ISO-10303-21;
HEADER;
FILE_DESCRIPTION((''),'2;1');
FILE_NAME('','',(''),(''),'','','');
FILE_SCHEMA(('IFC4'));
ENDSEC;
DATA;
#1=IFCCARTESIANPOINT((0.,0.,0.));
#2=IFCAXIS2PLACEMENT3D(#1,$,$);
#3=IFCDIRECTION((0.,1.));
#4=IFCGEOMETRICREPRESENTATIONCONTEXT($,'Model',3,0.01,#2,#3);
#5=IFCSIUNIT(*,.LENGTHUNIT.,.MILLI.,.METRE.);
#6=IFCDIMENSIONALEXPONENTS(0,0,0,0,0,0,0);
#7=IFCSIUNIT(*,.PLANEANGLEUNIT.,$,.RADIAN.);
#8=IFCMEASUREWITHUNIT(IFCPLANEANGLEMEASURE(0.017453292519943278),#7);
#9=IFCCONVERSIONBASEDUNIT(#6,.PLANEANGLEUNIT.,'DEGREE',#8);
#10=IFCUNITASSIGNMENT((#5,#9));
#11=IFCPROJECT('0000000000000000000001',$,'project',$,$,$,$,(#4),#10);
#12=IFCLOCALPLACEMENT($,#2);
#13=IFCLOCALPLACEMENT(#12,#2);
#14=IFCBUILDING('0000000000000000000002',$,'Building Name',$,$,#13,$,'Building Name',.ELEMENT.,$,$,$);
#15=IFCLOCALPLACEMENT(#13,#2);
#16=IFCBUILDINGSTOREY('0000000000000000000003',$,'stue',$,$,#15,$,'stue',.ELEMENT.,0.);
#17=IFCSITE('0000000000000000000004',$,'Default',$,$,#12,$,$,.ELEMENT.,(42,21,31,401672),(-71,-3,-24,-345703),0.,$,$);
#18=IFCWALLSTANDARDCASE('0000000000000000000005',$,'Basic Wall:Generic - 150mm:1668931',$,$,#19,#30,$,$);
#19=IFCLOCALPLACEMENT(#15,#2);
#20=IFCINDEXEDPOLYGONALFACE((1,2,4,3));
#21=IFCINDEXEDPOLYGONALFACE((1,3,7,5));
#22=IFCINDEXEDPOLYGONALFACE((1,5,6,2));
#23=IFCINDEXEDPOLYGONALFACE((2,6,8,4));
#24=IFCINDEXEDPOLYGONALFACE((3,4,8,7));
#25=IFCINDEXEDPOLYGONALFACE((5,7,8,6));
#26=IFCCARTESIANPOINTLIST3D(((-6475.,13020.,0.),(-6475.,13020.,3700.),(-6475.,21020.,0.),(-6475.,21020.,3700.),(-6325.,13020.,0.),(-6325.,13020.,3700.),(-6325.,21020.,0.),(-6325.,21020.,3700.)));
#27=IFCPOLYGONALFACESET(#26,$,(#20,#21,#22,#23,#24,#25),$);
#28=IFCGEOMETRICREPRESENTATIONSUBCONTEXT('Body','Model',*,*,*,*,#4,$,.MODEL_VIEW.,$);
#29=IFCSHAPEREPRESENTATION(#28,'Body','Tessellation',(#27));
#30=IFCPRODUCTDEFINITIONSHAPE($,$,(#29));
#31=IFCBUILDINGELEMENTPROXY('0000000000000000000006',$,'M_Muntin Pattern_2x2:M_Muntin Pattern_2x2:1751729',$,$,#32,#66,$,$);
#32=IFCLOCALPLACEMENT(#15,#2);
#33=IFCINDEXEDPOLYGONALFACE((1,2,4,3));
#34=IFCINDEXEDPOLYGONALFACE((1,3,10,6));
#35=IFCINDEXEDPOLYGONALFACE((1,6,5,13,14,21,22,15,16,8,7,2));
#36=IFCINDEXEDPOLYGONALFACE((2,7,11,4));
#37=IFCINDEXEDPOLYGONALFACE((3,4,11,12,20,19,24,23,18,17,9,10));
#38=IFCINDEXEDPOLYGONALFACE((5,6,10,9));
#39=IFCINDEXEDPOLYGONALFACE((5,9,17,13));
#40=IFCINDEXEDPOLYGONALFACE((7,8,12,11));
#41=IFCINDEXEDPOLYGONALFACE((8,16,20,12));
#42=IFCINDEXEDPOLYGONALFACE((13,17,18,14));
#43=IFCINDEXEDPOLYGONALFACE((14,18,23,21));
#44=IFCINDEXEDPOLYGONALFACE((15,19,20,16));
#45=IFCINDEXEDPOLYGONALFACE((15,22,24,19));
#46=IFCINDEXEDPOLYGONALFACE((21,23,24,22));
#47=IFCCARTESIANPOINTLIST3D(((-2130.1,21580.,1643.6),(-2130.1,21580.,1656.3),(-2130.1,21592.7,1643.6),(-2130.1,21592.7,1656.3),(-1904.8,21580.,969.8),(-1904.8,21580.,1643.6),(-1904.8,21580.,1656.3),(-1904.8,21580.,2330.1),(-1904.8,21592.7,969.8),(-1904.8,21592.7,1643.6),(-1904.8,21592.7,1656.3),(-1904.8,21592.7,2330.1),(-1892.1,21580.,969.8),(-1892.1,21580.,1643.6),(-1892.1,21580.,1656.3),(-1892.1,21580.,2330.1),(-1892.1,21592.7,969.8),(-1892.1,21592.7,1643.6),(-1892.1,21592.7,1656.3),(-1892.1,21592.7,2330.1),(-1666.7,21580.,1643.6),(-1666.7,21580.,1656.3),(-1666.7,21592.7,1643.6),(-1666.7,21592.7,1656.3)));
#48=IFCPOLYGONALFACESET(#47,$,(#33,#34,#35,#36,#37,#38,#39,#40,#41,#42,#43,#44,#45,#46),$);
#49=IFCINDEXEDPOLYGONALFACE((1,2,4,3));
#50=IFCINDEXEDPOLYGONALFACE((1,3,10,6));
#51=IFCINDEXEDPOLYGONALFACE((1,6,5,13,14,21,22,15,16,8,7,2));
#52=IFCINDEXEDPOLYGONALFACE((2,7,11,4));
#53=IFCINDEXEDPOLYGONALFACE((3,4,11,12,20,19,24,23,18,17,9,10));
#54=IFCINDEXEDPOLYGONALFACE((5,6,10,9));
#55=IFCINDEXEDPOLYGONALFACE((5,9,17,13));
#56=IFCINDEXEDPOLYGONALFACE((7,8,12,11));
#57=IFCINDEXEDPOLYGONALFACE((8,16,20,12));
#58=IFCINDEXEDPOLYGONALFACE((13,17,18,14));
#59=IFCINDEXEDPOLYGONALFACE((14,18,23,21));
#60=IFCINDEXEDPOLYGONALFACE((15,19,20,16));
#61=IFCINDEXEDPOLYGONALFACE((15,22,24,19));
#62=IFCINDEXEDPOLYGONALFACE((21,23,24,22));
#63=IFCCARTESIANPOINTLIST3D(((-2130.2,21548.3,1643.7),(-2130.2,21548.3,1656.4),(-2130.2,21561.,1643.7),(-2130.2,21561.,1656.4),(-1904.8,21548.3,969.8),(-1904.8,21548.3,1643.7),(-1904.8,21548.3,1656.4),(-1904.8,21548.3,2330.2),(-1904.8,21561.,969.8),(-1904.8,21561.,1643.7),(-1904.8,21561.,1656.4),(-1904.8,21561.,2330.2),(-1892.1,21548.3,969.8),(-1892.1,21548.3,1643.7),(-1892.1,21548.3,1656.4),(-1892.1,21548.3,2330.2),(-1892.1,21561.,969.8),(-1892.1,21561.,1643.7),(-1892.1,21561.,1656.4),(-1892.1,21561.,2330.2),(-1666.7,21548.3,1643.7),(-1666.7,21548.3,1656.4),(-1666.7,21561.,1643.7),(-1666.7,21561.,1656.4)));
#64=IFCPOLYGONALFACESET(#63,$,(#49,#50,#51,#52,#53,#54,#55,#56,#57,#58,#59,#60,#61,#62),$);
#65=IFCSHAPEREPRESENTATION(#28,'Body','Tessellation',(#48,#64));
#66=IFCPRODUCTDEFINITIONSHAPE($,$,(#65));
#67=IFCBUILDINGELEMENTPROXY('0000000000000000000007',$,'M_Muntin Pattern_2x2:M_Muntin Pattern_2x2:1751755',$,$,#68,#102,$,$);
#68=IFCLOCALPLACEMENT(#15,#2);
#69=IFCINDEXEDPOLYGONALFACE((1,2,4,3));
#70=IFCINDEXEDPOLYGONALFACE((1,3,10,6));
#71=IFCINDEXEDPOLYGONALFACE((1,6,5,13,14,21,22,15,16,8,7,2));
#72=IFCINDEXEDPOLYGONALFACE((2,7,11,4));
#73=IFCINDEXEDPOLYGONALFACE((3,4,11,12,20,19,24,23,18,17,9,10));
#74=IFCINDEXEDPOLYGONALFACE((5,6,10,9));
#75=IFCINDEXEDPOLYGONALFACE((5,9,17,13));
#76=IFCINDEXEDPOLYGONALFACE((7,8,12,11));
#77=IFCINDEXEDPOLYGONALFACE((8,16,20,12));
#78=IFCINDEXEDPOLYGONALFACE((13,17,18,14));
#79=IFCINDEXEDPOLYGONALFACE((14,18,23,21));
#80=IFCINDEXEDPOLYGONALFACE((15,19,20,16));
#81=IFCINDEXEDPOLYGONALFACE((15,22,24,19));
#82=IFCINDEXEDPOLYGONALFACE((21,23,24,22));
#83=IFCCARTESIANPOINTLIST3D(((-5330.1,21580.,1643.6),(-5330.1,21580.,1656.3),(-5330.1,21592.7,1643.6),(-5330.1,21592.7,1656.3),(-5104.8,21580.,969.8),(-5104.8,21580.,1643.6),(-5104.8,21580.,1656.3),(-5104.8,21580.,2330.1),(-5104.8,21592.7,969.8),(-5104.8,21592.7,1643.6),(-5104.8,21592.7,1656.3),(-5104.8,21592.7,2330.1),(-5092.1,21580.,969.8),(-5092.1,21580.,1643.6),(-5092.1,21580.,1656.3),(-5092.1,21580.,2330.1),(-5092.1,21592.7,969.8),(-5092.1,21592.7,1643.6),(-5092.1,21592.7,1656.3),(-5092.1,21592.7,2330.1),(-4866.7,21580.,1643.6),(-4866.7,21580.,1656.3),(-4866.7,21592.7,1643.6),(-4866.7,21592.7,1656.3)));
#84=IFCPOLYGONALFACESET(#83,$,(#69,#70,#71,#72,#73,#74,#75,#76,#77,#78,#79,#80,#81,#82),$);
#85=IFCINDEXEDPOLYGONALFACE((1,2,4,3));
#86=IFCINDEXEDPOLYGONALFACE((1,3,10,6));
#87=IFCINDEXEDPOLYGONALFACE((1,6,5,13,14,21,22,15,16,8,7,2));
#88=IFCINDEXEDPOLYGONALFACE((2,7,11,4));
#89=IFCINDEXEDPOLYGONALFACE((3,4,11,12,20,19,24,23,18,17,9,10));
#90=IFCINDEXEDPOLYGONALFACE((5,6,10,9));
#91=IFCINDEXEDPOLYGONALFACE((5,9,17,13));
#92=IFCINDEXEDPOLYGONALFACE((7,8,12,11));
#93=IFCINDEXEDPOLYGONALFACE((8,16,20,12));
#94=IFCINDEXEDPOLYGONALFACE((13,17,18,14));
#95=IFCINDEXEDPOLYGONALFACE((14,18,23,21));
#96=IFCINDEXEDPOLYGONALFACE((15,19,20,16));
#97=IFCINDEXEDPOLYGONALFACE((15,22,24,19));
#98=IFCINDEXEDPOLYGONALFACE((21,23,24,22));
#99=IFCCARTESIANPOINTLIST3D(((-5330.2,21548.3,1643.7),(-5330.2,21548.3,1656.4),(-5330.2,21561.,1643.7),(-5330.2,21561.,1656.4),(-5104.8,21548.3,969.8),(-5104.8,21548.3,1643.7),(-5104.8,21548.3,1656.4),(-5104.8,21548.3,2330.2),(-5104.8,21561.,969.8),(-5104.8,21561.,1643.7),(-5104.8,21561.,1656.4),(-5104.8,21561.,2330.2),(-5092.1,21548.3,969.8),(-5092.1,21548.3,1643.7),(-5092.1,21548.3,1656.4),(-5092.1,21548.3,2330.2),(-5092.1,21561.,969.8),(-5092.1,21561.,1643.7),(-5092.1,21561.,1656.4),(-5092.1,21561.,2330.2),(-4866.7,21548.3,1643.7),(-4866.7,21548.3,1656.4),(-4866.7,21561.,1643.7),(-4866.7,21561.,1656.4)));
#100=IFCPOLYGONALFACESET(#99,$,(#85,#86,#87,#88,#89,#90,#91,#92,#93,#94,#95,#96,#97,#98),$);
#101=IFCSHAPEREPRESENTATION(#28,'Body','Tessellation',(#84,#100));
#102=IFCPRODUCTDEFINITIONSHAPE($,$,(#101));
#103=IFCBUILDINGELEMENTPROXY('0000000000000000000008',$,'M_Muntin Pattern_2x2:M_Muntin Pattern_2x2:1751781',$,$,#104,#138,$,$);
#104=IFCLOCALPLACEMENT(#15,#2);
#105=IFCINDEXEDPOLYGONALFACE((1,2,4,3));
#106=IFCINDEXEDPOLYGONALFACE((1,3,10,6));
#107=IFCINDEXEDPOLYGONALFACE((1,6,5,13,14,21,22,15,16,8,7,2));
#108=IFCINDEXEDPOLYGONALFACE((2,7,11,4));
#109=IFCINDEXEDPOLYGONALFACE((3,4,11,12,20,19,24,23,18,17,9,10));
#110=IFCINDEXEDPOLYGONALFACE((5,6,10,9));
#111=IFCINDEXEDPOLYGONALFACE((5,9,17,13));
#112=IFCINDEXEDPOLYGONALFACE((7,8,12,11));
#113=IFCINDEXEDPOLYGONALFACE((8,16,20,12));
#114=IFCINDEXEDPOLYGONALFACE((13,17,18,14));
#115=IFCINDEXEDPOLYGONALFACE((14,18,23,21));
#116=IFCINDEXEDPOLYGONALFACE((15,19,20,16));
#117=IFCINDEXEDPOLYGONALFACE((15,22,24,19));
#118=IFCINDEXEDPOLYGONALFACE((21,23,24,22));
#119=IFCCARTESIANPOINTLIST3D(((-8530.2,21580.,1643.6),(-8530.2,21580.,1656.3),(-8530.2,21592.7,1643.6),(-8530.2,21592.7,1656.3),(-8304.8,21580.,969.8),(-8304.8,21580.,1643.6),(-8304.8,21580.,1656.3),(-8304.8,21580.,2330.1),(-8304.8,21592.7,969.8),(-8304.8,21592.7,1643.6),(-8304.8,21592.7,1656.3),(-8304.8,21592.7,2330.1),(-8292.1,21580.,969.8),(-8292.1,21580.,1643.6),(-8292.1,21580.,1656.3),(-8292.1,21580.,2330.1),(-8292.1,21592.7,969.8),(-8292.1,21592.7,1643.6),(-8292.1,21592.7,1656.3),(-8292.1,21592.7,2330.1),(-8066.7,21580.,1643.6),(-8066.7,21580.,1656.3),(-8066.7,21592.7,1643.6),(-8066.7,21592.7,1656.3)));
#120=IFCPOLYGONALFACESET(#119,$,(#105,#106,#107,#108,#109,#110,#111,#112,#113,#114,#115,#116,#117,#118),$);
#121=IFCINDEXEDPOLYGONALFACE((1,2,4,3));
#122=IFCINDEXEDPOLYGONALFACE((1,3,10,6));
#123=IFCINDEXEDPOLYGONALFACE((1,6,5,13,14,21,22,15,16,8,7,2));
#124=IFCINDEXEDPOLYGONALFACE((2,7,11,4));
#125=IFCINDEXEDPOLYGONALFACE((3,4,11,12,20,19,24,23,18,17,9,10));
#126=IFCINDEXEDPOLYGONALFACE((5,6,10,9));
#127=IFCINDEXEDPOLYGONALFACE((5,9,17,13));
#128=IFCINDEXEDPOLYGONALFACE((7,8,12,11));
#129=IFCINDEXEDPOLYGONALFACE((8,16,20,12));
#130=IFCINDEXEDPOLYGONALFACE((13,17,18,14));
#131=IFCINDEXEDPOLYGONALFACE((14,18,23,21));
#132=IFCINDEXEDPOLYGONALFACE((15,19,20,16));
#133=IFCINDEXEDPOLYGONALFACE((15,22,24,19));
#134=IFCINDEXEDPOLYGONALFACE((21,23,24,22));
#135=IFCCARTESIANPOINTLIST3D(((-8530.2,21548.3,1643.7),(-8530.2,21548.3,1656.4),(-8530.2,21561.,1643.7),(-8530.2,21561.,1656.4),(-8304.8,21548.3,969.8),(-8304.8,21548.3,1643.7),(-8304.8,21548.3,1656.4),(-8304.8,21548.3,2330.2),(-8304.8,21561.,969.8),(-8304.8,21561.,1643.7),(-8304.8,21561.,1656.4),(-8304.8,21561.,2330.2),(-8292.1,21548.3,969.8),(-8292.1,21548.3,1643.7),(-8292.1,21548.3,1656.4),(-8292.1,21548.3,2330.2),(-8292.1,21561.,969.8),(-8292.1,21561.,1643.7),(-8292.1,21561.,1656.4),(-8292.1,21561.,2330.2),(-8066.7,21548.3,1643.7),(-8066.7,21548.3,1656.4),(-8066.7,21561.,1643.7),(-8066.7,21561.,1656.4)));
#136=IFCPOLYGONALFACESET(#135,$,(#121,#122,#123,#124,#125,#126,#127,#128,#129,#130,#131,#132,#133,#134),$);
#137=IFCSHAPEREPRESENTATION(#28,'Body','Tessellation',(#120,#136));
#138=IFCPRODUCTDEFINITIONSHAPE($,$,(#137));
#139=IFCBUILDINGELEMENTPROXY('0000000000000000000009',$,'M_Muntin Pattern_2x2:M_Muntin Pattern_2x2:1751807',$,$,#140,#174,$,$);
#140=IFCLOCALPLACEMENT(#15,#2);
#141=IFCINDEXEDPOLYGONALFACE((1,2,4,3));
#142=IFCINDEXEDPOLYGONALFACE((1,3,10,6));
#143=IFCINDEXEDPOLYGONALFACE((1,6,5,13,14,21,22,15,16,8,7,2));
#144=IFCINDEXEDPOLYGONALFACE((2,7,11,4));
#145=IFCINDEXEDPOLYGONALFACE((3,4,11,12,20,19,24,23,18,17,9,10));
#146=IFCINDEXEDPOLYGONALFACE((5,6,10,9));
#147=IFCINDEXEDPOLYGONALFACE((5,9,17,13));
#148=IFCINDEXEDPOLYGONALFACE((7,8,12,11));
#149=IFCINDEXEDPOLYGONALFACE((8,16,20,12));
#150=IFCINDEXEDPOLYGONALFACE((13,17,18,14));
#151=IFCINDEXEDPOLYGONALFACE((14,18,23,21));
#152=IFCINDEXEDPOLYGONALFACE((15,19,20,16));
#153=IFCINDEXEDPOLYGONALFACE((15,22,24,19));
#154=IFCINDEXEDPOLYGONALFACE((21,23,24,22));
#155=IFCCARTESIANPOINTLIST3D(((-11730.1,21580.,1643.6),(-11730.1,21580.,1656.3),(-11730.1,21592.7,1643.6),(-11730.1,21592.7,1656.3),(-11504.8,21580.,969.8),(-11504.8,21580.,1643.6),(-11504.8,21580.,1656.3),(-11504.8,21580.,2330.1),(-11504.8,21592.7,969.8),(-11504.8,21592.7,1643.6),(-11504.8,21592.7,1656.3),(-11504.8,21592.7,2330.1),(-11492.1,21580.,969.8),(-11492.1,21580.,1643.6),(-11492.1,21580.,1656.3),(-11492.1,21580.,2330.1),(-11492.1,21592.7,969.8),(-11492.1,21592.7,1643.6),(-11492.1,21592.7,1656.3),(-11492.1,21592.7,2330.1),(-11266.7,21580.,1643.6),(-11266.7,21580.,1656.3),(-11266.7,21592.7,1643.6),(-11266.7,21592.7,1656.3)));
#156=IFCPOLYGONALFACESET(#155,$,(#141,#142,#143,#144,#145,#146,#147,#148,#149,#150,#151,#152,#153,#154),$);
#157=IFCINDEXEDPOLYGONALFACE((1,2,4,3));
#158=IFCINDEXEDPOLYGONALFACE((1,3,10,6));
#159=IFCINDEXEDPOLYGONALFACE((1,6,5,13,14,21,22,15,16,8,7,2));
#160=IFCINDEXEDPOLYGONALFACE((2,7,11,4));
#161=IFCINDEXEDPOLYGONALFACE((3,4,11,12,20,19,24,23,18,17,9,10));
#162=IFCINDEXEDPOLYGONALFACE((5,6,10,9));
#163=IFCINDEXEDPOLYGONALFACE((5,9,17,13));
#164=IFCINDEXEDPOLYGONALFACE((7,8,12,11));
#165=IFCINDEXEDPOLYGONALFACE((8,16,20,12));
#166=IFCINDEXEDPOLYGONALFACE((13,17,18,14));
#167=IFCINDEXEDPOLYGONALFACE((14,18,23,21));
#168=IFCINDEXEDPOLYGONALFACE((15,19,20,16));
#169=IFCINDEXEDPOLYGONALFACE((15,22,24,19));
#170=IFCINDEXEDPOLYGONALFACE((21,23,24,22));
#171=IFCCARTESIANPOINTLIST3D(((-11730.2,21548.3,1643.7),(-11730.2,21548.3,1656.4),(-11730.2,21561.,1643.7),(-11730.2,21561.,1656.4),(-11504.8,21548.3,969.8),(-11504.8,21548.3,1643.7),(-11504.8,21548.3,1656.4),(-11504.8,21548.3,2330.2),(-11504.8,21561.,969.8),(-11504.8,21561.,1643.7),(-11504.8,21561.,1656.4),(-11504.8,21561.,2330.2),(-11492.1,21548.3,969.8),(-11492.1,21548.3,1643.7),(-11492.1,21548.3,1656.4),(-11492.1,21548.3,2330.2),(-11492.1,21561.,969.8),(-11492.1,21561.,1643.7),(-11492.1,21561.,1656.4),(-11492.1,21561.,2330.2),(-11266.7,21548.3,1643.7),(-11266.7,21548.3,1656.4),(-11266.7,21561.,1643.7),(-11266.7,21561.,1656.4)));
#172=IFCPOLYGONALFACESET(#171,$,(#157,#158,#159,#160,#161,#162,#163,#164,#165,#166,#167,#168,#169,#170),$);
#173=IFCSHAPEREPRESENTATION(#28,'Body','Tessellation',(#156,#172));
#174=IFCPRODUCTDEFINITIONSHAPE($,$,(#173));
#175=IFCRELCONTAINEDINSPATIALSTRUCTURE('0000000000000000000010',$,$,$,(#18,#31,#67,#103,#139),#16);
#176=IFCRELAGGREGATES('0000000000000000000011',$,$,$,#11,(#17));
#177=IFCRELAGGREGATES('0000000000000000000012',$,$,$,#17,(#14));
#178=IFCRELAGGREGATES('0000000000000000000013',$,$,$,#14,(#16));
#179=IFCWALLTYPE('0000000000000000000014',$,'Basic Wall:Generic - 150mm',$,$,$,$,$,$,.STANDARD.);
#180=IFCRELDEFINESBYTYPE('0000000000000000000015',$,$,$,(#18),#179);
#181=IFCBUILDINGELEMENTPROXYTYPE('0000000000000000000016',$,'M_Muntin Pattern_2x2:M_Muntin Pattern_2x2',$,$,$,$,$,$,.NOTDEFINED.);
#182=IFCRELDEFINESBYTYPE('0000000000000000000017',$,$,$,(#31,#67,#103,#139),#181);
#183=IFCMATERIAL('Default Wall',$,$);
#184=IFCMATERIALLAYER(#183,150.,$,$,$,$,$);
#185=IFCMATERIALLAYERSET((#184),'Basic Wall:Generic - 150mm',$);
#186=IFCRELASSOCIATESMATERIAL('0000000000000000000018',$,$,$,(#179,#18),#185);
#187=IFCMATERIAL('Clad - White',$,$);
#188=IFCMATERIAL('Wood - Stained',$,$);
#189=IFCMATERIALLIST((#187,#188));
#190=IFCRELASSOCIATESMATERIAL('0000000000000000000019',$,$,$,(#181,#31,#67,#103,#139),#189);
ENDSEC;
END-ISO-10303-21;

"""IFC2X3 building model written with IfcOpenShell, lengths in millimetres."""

from ifc_helpers import new_model, entity, si_unit, converted_unit, direction, frame, frame_2d, origin, place, context, subcontext, project, spatial, polyline, rectangle, outline, extrude, clip, bounded_halfspace, source, transform, mapped, material, material_list, layer, layer_set, layer_usage, type_object, type_shapes, element, save


model = new_model("IFC2X3")

# Units and contexts
model_context = context("Model", 3, precision=0.01, world=origin(), true_north=direction((0.0, 1.0)))
body_context = subcontext(model_context, "Body", "Model", "MODEL_VIEW")
ifc_project = project(units=[si_unit("LENGTHUNIT", "METRE", prefix="MILLI"), converted_unit("PLANEANGLEUNIT", "DEGREE", entity("IfcPlaneAngleMeasure", 0.017453292519943278), si_unit("PLANEANGLEUNIT", "RADIAN"), dimensions=[0, 0, 0, 0, 0, 0, 0])], contexts=[model_context])

# Site, building, storey
site_placement = place(None, origin())
site = spatial("IfcSite", under=ifc_project, at=site_placement, Name="Default", CompositionType="ELEMENT", RefLatitude=(42, 21, 31, 401672), RefLongitude=(-71, -3, -24, -345703), RefElevation=0.0)
building_placement = place(site_placement, origin())
building = spatial("IfcBuilding", under=site, at=building_placement, Name="Building Name", LongName="Building Name", CompositionType="ELEMENT")
storey_placement = place(building_placement, origin())
storey = spatial("IfcBuildingStorey", under=building, at=storey_placement, Name="stue", LongName="stue", CompositionType="ELEMENT", Elevation=0.0)

# Wall
ifc_material_1 = material(Name="Default Wall")
ifc_layer = layer(ifc_material_1, 150.0)
ifc_layer_set = layer_set([ifc_layer], Name="Basic Wall:Generic - 150mm")
ifc_layer_usage = layer_usage(ifc_layer_set, "AXIS2", "NEGATIVE", 75.0)
wall_type = type_object("IfcWallType", Name="Basic Wall:Generic - 150mm", PredefinedType="STANDARD", material=ifc_layer_set)
wall_placement = place(storey_placement, frame((-6400.0, 21020.0, 0.0), z_axis=(0.0, 0.0, 1.0), x_axis=(0.0, -1.0, 0.0)))
element("IfcWallStandardCase", 1, at=wall_placement, inside=storey, type_object=wall_type, material=ifc_layer_usage, Name="Basic Wall:Generic - 150mm:1668931", context=body_context, shape_type="Clipping", body=[
    clip(extrude(rectangle(XDim=8000.0, YDim=150.0, at=frame_2d((4000.0, 0.0), x_axis=(-1.0, 0.0))), origin(), (0.0, 0.0, 1.0), 3700.0), bounded_halfspace(frame((0.0, -75.0, 3700.0), z_axis=(0.0, 0.0, -1.0), x_axis=(1.0, 0.0, 0.0)), True, frame((0.0, -75.0, 3700.0)), polyline([(0.0, 0.0), (8000.0, 0.0), (8000.0, 150.0), (0.0, 150.0), (0.0, 0.0)]))),
])

# Building element proxies
ifc_material_2 = material(Name="Clad - White")
ifc_material_3 = material(Name="Wood - Stained")
ifc_material_list = material_list([ifc_material_2, ifc_material_3])
building_element_proxy_type_1 = type_object("IfcBuildingElementProxyType", Name="M_Muntin Pattern_2x2:M_Muntin Pattern_2x2", PredefinedType="NOTDEFINED", material=ifc_material_list)
shared_shape_1 = source(origin(), body_context, "Body", "SweptSolid", [
    extrude(outline(polyline([(6.4, -6.4), (680.1, -6.4), (680.1, 6.3), (6.4, 6.3), (6.4, 231.7), (-6.3, 231.7), (-6.3, 6.3), (-680.2, 6.3), (-680.2, -6.4), (-6.3, -6.4), (-6.3, -231.7), (6.4, -231.7), (6.4, -6.4)])), frame((0.0, 9.5, 680.1), z_axis=(0.0, 1.0, 0.0), x_axis=(0.0, 0.0, 1.0)), (0.0, 0.0, 1.0), 12.7),
    extrude(outline(polyline([(6.4, -6.4), (680.2, -6.4), (680.2, 6.3), (6.4, 6.3), (6.4, 231.7), (-6.3, 231.7), (-6.3, 6.3), (-680.2, 6.3), (-680.2, -6.4), (-6.3, -6.4), (-6.3, -231.7), (6.4, -231.7), (6.4, -6.4)])), frame((0.0, -22.2, 680.2), z_axis=(0.0, 1.0, 0.0), x_axis=(0.0, 0.0, 1.0)), (0.0, 0.0, 1.0), 12.7),
])
type_shapes(building_element_proxy_type_1, [shared_shape_1])
for number, where, name in (
    (2, (-1898.4, 21570.5, 969.8), "M_Muntin Pattern_2x2:M_Muntin Pattern_2x2:1751729"),
    (3, (-5098.4, 21570.5, 969.8), "M_Muntin Pattern_2x2:M_Muntin Pattern_2x2:1751755"),
    (4, (-8298.4, 21570.5, 969.8), "M_Muntin Pattern_2x2:M_Muntin Pattern_2x2:1751781"),
    (5, (-11498.4, 21570.5, 969.8), "M_Muntin Pattern_2x2:M_Muntin Pattern_2x2:1751807"),
):
    element("IfcBuildingElementProxy", number, at=place(storey_placement, frame(where)), inside=storey, type_object=building_element_proxy_type_1, material=ifc_material_list, Name=name, context=body_context, shape_type="MappedRepresentation", body=[
        mapped(shared_shape_1, transform((0.0, 0.0, 0.0), scale=1.0)),
    ])

save(model, "model.ifc")
